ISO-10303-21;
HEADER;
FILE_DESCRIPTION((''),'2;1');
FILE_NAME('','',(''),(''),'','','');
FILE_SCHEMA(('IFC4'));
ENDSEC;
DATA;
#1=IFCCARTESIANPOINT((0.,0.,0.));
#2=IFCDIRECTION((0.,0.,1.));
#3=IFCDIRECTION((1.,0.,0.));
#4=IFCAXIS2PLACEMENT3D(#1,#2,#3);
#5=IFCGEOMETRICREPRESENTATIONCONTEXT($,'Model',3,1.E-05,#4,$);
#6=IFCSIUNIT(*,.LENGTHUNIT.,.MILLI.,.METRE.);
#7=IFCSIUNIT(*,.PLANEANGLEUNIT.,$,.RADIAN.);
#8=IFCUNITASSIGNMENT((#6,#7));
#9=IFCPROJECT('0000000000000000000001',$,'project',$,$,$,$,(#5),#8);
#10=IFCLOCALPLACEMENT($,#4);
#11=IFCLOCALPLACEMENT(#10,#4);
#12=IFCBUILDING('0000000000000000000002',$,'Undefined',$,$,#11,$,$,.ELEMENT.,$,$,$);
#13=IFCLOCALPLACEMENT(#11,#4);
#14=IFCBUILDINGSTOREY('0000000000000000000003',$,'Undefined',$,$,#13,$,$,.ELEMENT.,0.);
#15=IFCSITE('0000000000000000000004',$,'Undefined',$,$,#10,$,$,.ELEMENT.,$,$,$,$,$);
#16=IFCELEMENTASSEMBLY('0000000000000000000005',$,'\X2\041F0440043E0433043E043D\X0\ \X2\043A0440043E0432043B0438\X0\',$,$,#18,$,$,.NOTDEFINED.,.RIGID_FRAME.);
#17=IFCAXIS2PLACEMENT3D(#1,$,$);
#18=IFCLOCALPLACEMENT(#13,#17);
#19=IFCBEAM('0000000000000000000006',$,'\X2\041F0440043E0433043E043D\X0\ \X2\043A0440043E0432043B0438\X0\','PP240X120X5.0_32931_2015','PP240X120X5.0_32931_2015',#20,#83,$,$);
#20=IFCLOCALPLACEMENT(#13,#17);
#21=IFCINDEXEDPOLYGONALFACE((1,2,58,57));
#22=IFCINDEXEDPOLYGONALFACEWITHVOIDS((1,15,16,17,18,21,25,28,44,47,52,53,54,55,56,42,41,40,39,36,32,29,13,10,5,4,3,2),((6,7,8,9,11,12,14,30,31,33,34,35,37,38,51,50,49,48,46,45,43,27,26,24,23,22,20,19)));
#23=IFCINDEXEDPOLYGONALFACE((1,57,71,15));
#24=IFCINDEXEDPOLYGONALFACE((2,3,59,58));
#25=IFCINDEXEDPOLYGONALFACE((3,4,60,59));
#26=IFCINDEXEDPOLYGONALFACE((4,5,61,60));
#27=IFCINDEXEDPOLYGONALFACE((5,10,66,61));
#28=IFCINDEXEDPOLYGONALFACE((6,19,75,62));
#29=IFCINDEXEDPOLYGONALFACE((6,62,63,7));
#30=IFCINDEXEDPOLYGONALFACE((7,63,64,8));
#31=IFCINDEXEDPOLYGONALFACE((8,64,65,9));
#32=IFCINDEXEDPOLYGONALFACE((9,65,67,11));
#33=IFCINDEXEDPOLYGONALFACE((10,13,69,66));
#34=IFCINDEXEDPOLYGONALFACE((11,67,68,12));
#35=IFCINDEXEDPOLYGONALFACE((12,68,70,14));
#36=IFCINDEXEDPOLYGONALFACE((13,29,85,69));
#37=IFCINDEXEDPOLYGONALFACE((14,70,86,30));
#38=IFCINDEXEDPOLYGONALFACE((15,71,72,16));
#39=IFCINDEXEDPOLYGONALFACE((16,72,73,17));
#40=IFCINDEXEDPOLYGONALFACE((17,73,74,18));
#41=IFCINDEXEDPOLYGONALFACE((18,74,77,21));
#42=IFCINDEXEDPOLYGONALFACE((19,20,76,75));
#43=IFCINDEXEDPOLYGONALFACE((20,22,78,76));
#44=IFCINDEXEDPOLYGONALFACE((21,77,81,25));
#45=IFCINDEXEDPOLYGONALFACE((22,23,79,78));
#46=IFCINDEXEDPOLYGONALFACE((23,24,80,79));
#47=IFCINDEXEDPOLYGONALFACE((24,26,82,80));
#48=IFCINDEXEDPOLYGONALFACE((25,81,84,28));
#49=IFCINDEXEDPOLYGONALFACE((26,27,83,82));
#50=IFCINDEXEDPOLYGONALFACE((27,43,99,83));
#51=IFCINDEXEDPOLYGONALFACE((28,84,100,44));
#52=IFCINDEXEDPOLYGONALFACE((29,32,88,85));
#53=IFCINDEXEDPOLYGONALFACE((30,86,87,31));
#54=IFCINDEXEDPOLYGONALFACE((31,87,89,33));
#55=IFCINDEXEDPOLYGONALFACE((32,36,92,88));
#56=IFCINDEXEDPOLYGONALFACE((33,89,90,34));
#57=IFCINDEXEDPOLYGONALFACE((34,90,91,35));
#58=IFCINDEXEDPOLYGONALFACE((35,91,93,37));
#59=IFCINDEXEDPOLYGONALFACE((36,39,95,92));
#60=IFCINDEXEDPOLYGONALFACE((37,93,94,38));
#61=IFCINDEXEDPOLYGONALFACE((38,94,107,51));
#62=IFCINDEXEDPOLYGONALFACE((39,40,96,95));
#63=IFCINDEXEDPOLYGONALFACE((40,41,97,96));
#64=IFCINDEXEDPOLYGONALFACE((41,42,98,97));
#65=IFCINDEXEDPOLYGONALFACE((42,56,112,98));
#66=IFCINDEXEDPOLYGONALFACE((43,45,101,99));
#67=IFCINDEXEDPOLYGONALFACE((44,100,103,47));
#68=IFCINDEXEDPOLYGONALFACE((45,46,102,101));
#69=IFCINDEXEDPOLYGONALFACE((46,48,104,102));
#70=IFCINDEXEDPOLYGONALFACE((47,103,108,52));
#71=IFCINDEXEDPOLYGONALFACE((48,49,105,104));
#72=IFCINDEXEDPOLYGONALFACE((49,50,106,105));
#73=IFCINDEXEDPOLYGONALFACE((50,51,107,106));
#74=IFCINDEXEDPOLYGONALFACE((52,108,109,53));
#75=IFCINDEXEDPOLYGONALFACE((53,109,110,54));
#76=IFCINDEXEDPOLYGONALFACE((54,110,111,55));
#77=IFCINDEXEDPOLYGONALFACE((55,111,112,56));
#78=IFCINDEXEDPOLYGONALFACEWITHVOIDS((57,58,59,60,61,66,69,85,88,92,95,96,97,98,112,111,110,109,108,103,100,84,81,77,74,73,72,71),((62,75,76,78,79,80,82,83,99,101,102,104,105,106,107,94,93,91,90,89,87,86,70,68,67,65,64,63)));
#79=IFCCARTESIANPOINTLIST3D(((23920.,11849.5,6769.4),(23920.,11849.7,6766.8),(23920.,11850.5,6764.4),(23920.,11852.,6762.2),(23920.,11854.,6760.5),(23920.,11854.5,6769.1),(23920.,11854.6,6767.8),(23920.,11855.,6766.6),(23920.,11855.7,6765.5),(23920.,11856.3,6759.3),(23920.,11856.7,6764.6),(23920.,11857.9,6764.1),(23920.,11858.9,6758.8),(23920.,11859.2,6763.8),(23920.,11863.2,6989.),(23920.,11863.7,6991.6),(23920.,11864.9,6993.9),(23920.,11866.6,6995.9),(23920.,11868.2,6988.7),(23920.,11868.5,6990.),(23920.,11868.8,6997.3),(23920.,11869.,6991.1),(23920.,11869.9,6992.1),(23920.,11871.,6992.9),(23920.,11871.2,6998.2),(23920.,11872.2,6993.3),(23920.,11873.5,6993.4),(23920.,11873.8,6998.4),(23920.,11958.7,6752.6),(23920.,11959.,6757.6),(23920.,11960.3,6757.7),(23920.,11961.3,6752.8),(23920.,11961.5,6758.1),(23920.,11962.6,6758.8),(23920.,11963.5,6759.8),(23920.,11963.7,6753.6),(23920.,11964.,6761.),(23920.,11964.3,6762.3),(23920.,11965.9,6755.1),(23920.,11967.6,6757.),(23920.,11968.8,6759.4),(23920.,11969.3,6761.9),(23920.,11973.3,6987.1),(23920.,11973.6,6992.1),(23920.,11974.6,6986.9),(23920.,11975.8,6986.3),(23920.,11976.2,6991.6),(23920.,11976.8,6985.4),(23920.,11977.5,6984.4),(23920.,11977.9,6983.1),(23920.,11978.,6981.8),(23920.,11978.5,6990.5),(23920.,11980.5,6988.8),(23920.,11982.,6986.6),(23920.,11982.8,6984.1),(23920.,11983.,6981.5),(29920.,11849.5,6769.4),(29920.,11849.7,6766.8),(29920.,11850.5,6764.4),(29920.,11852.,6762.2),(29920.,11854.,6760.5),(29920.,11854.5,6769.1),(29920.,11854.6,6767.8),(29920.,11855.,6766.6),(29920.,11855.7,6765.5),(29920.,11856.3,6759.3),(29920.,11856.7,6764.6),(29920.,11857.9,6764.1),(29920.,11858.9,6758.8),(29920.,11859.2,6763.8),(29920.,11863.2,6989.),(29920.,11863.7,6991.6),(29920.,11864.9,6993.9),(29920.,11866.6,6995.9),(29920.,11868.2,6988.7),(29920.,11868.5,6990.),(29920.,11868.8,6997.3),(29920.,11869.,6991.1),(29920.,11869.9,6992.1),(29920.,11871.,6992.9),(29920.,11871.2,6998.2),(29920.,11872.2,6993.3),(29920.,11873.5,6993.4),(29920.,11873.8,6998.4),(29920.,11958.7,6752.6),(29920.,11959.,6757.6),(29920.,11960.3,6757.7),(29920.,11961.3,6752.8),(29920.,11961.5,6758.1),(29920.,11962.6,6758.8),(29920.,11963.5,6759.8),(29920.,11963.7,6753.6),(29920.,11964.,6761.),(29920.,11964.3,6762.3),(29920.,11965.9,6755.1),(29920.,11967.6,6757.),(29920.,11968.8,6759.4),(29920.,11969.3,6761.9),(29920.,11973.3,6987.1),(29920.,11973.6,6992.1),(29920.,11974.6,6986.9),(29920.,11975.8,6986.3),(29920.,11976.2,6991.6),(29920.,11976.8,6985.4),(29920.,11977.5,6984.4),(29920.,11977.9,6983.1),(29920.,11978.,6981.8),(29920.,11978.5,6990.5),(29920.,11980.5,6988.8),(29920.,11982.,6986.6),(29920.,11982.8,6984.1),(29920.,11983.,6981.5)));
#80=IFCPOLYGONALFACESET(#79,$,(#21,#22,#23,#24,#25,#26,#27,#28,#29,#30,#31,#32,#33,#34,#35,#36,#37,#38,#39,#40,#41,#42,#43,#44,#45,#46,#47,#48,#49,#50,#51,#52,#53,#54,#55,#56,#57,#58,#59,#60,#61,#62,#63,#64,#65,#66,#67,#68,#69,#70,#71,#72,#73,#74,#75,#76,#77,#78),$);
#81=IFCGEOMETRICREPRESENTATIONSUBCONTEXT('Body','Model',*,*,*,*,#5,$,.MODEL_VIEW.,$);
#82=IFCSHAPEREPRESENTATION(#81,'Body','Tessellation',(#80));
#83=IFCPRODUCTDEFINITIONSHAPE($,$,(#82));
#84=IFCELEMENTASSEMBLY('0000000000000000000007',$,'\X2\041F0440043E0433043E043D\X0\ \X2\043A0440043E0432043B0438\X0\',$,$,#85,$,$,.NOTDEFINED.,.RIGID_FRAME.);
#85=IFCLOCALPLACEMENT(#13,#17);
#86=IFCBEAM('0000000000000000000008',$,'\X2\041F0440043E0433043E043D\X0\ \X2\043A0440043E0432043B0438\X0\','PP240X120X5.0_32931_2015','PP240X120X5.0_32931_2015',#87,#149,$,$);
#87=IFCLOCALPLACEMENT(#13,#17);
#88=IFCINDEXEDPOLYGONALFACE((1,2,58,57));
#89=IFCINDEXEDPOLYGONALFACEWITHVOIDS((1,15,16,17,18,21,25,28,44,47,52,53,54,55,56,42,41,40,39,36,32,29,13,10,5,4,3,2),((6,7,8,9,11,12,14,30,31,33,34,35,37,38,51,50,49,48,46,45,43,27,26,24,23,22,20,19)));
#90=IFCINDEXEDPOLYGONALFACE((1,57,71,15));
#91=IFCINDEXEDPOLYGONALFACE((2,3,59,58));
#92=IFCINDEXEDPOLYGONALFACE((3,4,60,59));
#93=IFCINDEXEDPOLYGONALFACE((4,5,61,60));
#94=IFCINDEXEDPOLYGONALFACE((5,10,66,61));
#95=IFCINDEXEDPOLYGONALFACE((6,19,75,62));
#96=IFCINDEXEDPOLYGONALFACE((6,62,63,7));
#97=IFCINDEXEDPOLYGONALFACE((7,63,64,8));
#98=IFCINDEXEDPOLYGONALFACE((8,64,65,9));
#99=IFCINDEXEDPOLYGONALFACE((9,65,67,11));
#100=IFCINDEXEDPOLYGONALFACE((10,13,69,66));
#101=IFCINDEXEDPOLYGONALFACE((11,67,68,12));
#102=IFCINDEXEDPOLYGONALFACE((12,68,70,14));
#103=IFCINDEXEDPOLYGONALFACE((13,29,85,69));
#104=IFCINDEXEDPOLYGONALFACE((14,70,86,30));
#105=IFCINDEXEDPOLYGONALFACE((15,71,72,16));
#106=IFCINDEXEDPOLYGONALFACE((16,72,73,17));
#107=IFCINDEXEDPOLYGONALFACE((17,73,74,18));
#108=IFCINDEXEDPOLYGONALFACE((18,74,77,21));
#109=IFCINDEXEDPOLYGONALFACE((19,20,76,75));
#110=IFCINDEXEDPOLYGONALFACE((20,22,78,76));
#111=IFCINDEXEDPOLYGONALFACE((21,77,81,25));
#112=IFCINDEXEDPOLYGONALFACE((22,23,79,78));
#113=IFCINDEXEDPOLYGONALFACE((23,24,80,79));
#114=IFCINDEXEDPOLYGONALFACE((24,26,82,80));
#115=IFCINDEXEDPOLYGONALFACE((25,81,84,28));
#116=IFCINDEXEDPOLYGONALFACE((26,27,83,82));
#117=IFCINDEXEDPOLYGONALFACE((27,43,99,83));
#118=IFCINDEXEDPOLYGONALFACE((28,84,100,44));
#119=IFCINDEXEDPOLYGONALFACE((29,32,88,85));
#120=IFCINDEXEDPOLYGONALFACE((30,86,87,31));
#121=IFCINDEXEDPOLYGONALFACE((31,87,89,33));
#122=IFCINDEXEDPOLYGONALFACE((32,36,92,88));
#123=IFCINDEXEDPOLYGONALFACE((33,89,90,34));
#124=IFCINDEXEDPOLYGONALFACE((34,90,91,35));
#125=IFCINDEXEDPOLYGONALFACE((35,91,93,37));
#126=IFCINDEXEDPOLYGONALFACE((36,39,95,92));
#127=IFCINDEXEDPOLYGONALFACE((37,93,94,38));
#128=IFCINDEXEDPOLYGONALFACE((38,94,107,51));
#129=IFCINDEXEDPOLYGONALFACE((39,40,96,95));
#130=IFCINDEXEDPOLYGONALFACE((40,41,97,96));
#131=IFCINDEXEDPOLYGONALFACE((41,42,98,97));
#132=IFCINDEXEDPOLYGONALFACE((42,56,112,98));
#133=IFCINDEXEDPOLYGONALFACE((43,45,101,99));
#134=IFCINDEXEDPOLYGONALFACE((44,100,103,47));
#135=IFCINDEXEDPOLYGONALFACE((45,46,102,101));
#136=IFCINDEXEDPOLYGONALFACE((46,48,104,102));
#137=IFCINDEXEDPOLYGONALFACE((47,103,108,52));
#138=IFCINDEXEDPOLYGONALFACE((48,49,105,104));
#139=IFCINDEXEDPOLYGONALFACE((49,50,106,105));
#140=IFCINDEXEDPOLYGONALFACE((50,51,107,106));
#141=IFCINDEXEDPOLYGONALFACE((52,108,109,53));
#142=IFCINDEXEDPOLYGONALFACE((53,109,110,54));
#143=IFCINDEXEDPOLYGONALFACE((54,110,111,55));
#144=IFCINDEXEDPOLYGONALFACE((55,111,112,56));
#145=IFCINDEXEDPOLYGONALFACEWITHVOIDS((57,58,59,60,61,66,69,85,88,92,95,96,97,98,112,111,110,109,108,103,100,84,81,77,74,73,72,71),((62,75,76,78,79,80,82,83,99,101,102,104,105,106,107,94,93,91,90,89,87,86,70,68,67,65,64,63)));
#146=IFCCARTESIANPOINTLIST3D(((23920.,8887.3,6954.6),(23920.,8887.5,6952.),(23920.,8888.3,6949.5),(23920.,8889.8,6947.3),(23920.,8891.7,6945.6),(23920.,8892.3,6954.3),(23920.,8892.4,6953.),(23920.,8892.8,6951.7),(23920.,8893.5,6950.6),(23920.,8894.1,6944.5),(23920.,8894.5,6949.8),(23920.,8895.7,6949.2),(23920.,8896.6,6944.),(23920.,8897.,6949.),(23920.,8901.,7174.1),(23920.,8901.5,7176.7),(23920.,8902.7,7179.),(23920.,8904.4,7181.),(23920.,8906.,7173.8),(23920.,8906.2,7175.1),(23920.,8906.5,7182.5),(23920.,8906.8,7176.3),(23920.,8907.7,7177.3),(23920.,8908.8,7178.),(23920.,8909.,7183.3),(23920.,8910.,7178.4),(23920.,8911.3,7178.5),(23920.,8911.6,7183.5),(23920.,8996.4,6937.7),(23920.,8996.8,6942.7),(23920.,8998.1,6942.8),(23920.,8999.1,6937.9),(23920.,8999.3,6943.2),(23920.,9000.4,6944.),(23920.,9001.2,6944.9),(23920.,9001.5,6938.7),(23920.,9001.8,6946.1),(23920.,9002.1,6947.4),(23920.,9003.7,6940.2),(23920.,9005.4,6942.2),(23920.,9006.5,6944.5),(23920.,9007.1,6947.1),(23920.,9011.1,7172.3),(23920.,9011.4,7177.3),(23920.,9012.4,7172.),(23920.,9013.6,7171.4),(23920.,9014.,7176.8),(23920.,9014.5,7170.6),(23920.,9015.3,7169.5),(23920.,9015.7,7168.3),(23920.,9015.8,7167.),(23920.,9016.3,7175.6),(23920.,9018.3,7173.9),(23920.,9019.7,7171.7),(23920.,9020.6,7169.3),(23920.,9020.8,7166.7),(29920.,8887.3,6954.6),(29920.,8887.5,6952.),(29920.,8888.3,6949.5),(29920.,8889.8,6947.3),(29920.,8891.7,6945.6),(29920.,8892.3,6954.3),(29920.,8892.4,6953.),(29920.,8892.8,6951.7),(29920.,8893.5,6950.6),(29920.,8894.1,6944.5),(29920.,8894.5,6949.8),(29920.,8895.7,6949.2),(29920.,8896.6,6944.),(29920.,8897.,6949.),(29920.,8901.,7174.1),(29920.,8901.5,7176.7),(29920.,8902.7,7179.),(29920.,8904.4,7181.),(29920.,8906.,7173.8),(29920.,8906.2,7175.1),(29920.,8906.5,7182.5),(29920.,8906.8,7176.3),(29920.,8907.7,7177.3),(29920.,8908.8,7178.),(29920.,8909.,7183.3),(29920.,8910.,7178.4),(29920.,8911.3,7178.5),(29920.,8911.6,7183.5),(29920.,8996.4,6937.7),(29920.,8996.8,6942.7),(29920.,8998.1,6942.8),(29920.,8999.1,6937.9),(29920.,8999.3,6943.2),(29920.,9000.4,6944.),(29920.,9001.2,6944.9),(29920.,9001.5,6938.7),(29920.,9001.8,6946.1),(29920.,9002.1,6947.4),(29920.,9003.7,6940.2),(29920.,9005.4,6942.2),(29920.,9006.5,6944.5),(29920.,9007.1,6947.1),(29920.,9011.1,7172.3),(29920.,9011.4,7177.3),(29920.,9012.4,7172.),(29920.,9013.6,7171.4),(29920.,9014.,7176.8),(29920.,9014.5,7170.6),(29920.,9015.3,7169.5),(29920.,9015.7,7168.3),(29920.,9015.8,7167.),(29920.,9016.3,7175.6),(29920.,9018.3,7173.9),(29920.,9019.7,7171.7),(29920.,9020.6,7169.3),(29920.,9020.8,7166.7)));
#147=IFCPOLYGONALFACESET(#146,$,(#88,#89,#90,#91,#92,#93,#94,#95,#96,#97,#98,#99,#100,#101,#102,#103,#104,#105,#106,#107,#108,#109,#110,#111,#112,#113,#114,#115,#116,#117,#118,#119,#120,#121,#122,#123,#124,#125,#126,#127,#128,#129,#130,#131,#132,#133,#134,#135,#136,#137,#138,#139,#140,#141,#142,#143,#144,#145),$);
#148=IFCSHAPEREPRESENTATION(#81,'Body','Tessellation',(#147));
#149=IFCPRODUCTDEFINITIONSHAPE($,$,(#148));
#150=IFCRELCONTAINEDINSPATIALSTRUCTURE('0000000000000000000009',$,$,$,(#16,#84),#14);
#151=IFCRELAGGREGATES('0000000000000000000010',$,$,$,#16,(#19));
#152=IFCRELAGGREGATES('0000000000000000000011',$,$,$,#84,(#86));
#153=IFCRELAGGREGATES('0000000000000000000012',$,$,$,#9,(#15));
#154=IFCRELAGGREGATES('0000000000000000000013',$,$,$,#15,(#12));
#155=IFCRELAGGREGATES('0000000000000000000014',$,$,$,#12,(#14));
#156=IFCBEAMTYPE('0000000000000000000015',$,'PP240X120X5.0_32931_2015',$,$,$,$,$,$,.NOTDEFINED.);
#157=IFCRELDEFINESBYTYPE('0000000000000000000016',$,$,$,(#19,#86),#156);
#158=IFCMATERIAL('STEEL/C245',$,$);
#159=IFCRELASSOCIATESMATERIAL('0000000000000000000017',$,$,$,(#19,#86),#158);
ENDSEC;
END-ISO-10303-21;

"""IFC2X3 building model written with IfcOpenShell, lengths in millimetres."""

from ifc_helpers import new_model, si_unit, frame, origin_with_axes, origin_2d_with_axis, place, context, subcontext, project, spatial, hollow_rectangle, extrude, material, type_object, element, aggregate, save


model = new_model("IFC2X3")

# Units and contexts
model_context = context("Model", 3, precision=1e-05, world=origin_with_axes())
body_context = subcontext(model_context, "Body", "Model", "MODEL_VIEW")
ifc_project = project(units=[si_unit("LENGTHUNIT", "METRE", prefix="MILLI"), si_unit("PLANEANGLEUNIT", "RADIAN")], contexts=[model_context])

# Site, building, storey
site_placement = place(None, origin_with_axes())
site = spatial("IfcSite", under=ifc_project, at=site_placement, Name="Undefined", CompositionType="ELEMENT")
building_placement = place(site_placement, origin_with_axes())
building = spatial("IfcBuilding", under=site, at=building_placement, Name="Undefined", CompositionType="ELEMENT")
storey_placement = place(building_placement, origin_with_axes())
storey = spatial("IfcBuildingStorey", under=building, at=storey_placement, Name="Undefined", CompositionType="ELEMENT", Elevation=0.0)

# Shared definitions
ifc_material = material(Name="STEEL/C245")

# Element assemblies, beams
assembly_1_placement = place(storey_placement, origin_with_axes())
assembly_1 = element("IfcElementAssembly", 1, at=assembly_1_placement, inside=storey, Name="Прогон кровли", AssemblyPlace="NOTDEFINED", PredefinedType="RIGID_FRAME")
beam_type_1 = type_object("IfcBeamType", Name="PP240X120X5.0_32931_2015", PredefinedType="NOTDEFINED")
beam_1_placement = place(assembly_1_placement, frame((29920.0, 11916.2, 6875.5), z_axis=(0.0, 0.062378, 0.998053), x_axis=(-1.0, 0.0, 0.0)))
beam_1 = element("IfcBeam", 2, at=beam_1_placement, type_object=beam_type_1, material=ifc_material, Name="Прогон кровли", Description="PP240X120X5.0_32931_2015", ObjectType="PP240X120X5.0_32931_2015", context=body_context, shape_type="SweptSolid", body=[
    extrude(hollow_rectangle(XDim=120.0, YDim=240.0, WallThickness=5.0, InnerFilletRadius=5.0, OuterFilletRadius=10.0, at=origin_2d_with_axis()), frame((6000.0, 0.0, 0.0), z_axis=(-1.0, 0.0, 0.0), x_axis=(0.0, -1.0, 0.0)), (0.0, 0.0, 1.0), 6000.0),
])
aggregate(assembly_1, [beam_1])
assembly_2_placement = place(storey_placement, origin_with_axes())
assembly_2 = element("IfcElementAssembly", 3, at=assembly_2_placement, inside=storey, Name="Прогон кровли", AssemblyPlace="NOTDEFINED", PredefinedType="RIGID_FRAME")
beam_2_placement = place(assembly_2_placement, frame((29920.0, 8954.0, 7060.6), z_axis=(0.0, 0.062378, 0.998053), x_axis=(-1.0, 0.0, 0.0)))
beam_2 = element("IfcBeam", 4, at=beam_2_placement, type_object=beam_type_1, material=ifc_material, Name="Прогон кровли", Description="PP240X120X5.0_32931_2015", ObjectType="PP240X120X5.0_32931_2015", context=body_context, shape_type="SweptSolid", body=[
    extrude(hollow_rectangle(XDim=120.0, YDim=240.0, WallThickness=5.0, InnerFilletRadius=5.0, OuterFilletRadius=10.0, at=origin_2d_with_axis()), frame((6000.0, 0.0, 0.0), z_axis=(-1.0, 0.0, 0.0), x_axis=(0.0, -1.0, 0.0)), (0.0, 0.0, 1.0), 6000.0),
])
aggregate(assembly_2, [beam_2])

save(model, "model.ifc")
